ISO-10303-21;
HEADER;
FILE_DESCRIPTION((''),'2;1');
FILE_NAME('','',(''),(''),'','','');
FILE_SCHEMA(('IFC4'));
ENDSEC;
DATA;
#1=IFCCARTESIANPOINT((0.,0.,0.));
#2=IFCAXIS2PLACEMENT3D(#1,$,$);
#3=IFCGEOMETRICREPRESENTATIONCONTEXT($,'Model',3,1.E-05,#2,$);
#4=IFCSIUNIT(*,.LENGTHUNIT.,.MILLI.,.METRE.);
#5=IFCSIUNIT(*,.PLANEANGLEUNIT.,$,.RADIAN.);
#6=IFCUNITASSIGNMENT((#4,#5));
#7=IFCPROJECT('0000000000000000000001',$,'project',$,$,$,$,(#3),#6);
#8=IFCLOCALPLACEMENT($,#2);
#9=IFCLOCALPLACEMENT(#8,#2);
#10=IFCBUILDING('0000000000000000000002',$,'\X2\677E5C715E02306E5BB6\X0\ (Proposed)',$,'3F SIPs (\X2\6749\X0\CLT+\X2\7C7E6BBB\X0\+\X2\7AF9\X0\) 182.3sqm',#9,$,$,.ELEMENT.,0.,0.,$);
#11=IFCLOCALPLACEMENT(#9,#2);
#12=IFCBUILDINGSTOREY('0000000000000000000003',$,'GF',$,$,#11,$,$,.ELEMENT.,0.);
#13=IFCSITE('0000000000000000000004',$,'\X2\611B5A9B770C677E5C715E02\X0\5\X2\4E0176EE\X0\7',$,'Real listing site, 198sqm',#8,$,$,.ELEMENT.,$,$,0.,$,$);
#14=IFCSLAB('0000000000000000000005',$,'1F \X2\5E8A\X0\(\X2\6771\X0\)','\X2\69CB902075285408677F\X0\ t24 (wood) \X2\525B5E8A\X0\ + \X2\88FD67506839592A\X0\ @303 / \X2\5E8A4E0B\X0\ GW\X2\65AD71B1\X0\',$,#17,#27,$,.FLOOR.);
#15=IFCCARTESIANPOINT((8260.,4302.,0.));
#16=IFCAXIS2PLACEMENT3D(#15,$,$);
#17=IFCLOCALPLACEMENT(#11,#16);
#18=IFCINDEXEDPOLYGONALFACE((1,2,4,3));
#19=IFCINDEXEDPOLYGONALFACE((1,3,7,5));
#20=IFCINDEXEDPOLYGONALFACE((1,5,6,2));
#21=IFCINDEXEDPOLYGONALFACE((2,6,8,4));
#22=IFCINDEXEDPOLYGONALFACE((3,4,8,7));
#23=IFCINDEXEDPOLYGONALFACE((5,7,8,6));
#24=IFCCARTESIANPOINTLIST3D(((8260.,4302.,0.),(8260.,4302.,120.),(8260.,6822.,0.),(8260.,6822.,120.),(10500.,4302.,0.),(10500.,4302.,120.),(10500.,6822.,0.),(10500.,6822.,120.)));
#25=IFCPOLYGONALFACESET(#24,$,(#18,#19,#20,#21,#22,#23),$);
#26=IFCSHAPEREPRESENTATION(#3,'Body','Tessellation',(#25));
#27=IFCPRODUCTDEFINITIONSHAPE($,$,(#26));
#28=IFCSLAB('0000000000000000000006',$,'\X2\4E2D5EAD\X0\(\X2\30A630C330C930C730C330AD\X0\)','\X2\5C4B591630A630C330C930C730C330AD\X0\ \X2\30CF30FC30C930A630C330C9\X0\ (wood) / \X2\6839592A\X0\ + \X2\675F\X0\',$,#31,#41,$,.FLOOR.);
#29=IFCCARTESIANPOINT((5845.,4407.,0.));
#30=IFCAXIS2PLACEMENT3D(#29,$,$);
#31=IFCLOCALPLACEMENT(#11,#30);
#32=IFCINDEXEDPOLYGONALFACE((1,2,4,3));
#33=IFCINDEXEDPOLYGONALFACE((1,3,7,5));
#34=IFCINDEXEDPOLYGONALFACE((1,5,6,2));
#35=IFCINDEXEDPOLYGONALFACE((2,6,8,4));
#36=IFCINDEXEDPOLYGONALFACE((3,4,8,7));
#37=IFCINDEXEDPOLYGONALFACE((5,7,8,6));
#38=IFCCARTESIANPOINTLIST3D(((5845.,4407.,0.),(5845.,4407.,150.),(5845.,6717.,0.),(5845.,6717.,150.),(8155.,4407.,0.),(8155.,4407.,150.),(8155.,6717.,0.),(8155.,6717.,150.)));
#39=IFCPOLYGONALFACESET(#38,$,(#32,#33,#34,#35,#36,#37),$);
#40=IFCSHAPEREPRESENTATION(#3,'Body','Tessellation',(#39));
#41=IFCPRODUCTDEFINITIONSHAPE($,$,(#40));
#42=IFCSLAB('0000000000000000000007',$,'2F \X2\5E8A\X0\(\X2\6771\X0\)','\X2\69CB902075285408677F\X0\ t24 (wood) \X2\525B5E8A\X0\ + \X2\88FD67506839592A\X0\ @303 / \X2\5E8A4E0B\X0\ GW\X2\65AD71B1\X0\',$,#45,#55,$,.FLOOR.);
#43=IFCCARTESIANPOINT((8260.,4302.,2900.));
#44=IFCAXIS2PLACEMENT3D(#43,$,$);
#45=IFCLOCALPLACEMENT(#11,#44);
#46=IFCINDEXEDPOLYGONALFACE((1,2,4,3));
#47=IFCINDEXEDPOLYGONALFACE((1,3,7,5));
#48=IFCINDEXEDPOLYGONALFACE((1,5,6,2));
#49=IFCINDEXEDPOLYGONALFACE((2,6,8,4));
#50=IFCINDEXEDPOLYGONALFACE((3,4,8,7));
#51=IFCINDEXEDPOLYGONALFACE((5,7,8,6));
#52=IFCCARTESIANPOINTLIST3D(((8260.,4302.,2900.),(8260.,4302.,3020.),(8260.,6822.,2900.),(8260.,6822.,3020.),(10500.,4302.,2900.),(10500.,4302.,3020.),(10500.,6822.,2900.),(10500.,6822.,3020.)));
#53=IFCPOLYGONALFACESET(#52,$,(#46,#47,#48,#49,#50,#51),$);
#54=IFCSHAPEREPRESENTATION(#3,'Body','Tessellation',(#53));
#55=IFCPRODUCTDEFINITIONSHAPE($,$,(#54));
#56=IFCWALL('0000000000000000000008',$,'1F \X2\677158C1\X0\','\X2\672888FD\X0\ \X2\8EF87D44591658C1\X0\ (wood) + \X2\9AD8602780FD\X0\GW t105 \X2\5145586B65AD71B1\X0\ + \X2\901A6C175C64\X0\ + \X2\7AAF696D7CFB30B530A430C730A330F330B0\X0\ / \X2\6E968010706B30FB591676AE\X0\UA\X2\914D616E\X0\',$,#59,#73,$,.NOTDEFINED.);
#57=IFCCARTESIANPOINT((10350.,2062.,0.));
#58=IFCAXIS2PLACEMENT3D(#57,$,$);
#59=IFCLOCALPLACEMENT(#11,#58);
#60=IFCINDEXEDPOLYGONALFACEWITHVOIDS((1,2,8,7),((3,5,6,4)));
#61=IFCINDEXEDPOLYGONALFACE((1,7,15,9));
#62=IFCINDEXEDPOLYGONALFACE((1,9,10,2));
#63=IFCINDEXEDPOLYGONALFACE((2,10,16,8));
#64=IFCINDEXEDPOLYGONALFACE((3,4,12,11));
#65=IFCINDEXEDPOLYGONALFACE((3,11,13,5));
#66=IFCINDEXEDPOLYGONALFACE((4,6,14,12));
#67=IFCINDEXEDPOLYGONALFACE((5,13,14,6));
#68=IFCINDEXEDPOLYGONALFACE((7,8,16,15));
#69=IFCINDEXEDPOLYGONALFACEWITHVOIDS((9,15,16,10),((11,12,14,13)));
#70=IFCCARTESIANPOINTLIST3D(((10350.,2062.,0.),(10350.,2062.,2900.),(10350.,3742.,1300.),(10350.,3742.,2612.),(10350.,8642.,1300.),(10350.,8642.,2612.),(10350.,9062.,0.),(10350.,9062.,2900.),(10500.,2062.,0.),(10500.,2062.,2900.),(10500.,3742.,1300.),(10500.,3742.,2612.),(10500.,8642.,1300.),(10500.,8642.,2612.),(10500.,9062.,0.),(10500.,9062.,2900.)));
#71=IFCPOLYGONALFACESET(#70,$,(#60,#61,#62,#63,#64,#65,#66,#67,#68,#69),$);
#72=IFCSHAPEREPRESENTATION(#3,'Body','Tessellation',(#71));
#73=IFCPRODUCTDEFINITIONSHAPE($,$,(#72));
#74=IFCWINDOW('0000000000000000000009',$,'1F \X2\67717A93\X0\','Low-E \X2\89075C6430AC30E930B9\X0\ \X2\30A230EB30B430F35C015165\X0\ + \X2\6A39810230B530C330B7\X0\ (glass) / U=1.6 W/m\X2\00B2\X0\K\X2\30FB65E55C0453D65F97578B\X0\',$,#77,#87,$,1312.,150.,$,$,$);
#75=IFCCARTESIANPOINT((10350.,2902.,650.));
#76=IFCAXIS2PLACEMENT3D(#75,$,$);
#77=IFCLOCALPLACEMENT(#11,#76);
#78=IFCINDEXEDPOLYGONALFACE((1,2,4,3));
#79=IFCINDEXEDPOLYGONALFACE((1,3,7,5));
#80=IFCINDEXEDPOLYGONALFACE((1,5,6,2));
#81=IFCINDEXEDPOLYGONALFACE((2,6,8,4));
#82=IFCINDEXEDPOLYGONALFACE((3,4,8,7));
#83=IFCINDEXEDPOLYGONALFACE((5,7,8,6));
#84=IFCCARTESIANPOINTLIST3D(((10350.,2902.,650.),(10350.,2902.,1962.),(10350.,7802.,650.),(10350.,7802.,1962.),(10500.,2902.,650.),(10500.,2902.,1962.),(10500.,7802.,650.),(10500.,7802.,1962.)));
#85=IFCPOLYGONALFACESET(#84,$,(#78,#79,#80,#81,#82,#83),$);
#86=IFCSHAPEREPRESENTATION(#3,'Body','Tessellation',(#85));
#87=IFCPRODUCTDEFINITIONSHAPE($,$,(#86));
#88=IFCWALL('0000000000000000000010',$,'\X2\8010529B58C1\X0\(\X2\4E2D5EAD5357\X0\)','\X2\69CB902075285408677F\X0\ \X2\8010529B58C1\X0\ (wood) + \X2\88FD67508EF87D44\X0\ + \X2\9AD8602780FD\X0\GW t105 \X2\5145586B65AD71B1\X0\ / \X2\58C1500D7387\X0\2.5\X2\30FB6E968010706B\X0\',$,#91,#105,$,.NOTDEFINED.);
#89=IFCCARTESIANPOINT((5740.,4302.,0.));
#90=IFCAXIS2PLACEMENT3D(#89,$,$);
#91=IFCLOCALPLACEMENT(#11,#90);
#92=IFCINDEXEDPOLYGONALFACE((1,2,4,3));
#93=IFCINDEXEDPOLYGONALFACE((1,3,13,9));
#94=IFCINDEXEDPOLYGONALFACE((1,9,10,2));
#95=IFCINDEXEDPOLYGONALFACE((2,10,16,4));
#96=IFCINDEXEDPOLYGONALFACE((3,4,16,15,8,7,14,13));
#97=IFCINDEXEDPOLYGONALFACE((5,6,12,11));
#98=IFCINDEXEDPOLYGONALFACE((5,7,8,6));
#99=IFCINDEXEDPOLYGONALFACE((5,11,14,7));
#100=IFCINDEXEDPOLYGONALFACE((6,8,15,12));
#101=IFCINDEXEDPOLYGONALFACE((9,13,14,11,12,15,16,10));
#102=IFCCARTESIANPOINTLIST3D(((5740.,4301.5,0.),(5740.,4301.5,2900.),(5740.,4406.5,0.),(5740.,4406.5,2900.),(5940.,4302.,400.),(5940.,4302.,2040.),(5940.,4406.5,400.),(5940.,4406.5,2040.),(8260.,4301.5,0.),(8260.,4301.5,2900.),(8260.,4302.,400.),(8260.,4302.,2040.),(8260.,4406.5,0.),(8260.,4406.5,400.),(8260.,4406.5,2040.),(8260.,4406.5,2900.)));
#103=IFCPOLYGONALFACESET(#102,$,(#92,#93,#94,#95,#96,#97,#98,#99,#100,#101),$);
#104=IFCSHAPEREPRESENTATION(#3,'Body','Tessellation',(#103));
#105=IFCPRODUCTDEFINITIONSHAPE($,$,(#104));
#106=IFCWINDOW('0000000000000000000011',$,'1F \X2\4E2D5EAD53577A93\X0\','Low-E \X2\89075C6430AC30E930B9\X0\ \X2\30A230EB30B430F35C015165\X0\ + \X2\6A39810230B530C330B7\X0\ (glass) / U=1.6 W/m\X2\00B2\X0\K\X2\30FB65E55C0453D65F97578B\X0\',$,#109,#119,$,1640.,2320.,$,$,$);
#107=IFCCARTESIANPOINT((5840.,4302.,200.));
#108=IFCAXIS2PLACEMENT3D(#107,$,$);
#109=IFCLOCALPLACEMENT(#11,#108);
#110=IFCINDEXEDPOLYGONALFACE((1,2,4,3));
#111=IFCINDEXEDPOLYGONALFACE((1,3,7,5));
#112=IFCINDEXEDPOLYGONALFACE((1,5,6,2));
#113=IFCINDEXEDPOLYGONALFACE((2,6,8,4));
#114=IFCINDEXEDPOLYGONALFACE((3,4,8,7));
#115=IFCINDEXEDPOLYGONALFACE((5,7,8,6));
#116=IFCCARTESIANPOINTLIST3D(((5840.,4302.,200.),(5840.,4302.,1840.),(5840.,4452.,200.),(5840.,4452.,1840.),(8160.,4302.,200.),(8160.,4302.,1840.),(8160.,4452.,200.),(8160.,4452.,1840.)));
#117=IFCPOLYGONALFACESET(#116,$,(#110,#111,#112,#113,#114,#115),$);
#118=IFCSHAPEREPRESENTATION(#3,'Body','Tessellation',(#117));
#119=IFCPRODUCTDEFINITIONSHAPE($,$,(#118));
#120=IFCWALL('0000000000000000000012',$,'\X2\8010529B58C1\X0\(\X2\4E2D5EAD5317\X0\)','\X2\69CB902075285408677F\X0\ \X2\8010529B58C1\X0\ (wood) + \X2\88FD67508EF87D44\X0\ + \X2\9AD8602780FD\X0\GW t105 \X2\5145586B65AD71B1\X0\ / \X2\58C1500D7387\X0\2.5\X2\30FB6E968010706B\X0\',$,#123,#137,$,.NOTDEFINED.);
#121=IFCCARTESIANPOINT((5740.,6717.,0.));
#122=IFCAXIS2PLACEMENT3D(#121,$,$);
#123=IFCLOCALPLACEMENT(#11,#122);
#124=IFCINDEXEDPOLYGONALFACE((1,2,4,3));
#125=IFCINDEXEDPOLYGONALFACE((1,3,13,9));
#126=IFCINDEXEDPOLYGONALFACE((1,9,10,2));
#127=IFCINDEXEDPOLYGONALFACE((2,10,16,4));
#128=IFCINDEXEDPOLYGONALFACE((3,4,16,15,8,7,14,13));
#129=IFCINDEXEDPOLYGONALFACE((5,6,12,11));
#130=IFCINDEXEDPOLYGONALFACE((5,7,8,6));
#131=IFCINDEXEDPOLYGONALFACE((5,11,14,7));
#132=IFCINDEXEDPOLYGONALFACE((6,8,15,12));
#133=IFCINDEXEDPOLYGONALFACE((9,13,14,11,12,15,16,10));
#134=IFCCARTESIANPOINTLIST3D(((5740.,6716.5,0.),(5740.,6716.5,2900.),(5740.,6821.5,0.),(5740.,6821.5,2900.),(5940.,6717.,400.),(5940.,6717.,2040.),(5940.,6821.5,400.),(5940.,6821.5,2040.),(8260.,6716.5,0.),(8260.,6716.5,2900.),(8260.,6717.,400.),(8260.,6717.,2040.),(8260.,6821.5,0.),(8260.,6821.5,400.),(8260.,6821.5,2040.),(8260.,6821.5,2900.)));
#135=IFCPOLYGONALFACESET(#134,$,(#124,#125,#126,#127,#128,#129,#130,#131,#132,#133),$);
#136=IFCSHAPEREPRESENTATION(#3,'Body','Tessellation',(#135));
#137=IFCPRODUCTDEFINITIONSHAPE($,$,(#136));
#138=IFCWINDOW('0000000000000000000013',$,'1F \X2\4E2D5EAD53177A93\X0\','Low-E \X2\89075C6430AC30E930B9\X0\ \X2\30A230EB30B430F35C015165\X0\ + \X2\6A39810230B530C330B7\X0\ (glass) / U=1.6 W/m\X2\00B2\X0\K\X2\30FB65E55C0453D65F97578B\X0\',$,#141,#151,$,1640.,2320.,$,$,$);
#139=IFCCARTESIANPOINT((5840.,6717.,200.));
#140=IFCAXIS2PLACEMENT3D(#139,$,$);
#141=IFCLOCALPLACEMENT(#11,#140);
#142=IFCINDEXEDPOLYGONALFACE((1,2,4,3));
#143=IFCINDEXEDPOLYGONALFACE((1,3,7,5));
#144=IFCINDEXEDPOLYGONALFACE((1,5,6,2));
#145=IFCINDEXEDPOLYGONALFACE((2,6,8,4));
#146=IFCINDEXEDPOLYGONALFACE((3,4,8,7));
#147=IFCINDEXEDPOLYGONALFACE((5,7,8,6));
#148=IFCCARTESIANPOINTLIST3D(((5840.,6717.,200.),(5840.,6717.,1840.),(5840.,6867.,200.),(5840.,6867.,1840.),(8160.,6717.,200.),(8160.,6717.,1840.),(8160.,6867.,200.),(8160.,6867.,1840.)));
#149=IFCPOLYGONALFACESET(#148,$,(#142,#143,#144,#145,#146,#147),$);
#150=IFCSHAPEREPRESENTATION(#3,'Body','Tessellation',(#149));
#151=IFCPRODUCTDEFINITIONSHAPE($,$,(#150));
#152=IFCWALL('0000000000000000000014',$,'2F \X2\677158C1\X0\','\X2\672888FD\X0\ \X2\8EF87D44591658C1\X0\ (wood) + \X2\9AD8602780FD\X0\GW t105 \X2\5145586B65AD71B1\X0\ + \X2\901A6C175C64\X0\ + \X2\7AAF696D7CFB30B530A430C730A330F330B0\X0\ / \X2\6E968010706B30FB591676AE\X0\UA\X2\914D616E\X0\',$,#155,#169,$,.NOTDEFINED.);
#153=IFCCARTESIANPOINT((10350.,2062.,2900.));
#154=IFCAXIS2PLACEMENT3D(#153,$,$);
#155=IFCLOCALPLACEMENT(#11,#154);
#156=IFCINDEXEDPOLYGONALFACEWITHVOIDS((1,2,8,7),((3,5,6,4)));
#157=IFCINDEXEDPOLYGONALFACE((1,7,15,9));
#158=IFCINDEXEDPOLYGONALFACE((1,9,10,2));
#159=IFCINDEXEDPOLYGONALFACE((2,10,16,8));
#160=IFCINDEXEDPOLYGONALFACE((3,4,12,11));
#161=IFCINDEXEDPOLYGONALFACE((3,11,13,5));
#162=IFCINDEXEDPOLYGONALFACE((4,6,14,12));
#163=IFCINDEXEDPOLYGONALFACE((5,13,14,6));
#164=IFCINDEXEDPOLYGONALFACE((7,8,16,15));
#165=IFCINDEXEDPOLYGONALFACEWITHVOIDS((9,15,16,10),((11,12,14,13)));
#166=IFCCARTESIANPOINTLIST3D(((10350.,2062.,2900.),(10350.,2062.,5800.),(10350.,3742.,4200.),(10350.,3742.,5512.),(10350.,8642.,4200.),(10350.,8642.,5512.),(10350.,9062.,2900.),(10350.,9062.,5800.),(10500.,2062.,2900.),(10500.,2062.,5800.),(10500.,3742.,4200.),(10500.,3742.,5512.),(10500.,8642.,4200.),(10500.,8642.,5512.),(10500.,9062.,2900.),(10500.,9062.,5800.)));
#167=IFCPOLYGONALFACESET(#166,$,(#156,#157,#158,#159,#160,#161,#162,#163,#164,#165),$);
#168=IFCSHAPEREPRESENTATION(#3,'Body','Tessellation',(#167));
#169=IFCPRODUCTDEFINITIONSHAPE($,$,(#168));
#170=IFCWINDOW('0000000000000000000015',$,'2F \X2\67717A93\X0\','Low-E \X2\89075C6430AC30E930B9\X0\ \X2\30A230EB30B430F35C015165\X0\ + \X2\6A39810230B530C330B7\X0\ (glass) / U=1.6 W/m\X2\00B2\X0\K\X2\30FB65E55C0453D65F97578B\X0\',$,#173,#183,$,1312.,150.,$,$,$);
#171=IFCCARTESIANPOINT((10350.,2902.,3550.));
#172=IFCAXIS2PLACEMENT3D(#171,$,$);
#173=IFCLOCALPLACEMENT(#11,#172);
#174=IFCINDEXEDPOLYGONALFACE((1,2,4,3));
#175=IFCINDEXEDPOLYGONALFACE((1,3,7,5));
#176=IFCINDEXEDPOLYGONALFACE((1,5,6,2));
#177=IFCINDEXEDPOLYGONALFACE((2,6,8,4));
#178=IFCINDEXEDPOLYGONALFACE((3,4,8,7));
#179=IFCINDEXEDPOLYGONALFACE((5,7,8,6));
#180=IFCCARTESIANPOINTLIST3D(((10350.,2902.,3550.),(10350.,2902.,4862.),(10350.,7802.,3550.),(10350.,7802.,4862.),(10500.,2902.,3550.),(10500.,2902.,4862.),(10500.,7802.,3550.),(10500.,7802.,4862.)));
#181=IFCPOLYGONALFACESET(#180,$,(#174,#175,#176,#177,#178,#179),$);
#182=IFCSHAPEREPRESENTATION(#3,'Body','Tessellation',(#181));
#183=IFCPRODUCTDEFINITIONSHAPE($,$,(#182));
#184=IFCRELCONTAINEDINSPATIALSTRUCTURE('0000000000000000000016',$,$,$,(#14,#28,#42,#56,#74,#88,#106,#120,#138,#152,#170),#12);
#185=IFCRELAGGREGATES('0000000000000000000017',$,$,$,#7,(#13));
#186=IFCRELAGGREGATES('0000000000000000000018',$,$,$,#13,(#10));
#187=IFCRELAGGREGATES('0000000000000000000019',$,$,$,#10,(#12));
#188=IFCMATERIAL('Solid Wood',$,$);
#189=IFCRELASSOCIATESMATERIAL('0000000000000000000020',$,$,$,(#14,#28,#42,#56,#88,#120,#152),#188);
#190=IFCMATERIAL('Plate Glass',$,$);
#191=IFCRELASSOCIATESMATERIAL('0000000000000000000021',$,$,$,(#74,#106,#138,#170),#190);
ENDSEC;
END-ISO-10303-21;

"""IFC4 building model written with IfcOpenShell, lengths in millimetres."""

from ifc_helpers import new_model, si_unit, frame, frame_2d, origin, place, context, project, spatial, rectangle, extrude, material, element, fill, save


model = new_model("IFC4")

# Units and contexts
model_context = context("Model", 3, precision=1e-05, world=origin())
ifc_project = project(units=[si_unit("LENGTHUNIT", "METRE", prefix="MILLI"), si_unit("PLANEANGLEUNIT", "RADIAN")], contexts=[model_context])

# Site, building, storey
site_placement = place(None, origin())
site = spatial("IfcSite", under=ifc_project, at=site_placement, Name="愛媛県松山市5丁目7", ObjectType="Real listing site, 198sqm", CompositionType="ELEMENT", RefElevation=0.0)
building_placement = place(site_placement, origin())
building = spatial("IfcBuilding", under=site, at=building_placement, Name="松山市の家 (Proposed)", ObjectType="3F SIPs (杉CLT+籾殻+竹) 182.3sqm", CompositionType="ELEMENT", ElevationOfRefHeight=0.0, ElevationOfTerrain=0.0)
storey_placement = place(building_placement, origin())
storey = spatial("IfcBuildingStorey", under=building, at=storey_placement, Name="GF", CompositionType="ELEMENT", Elevation=0.0)

# Slabs
ifc_material_1 = material(Name="Solid Wood")
slab_1_placement = place(storey_placement, frame((8260.0, 4302.0, 0.0)))
element("IfcSlab", 1, at=slab_1_placement, inside=storey, material=ifc_material_1, Name="1F 床(東)", Description="構造用合板 t24 (wood) 剛床 + 製材根太 @303 / 床下 GW断熱", PredefinedType="FLOOR", context=model_context, shape_type="SweptSolid", body=[
    extrude(rectangle(XDim=2240.0, YDim=2520.0, at=frame_2d((1120.0, 1260.0))), frame((8260.0, 4302.0, 0.0)), (0.0, 0.0, 1.0), 120.0),
])
slab_2_placement = place(storey_placement, frame((5845.0, 4407.0, 0.0)))
element("IfcSlab", 2, at=slab_2_placement, inside=storey, material=ifc_material_1, Name="中庭(ウッドデッキ)", Description="屋外ウッドデッキ ハードウッド (wood) / 根太 + 束", PredefinedType="FLOOR", context=model_context, shape_type="SweptSolid", body=[
    extrude(rectangle(XDim=2310.0, YDim=2310.0, at=frame_2d((1155.0, 1155.0))), frame((5845.0, 4407.0, 0.0)), (0.0, 0.0, 1.0), 150.0),
])
slab_3_placement = place(storey_placement, frame((8260.0, 4302.0, 2900.0)))
element("IfcSlab", 3, at=slab_3_placement, inside=storey, material=ifc_material_1, Name="2F 床(東)", Description="構造用合板 t24 (wood) 剛床 + 製材根太 @303 / 床下 GW断熱", PredefinedType="FLOOR", context=model_context, shape_type="SweptSolid", body=[
    extrude(rectangle(XDim=2240.0, YDim=2520.0, at=frame_2d((1120.0, 1260.0))), frame((8260.0, 4302.0, 2900.0)), (0.0, 0.0, 1.0), 120.0),
])

# Walls, openings, windows
wall_1_placement = place(storey_placement, frame((10350.0, 2062.0, 0.0)))
wall_1 = element("IfcWall", 4, at=wall_1_placement, inside=storey, material=ifc_material_1, Name="1F 東壁", Description="木製 軸組外壁 (wood) + 高性能GW t105 充填断熱 + 通気層 + 窯業系サイディング / 準耐火・外皮UA配慮", PredefinedType="NOTDEFINED", context=model_context, shape_type="SweptSolid", body=[
    extrude(rectangle(XDim=150.0, YDim=7000.0, at=frame_2d((75.0, 3500.0))), frame((10350.0, 2062.0, 0.0)), (0.0, 0.0, 1.0), 2900.0),
])
opening_1_placement = place(storey_placement, frame((10350.0, 2902.0, 650.0)))
opening_1 = element("IfcOpeningElement", 5, at=opening_1_placement, cuts=wall_1, PredefinedType="NOTDEFINED", context=model_context, shape_type="SweptSolid", body=[
    extrude(rectangle(XDim=150.0, YDim=4900.0, at=frame_2d((75.0, 2450.0))), frame((10350.0, 2902.0, 650.0)), (0.0, 0.0, 1.0), 1312.0),
])
ifc_material_2 = material(Name="Plate Glass")
window_1_placement = place(storey_placement, frame((10350.0, 2902.0, 650.0)))
window_1 = element("IfcWindow", 6, at=window_1_placement, inside=storey, material=ifc_material_2, Name="1F 東窓", Description="Low-E 複層ガラス アルゴン封入 + 樹脂サッシ (glass) / U=1.6 W/m²K・日射取得型", OverallHeight=1312.0, OverallWidth=150.0, context=model_context, shape_type="SweptSolid", body=[
    extrude(rectangle(XDim=150.0, YDim=4900.0, at=frame_2d((75.0, 2450.0))), frame((10350.0, 2902.0, 650.0)), (0.0, 0.0, 1.0), 1312.0),
])
fill(opening_1, window_1)
wall_2_placement = place(storey_placement, frame((5740.0, 4302.0, 0.0)))
wall_2 = element("IfcWall", 7, at=wall_2_placement, inside=storey, material=ifc_material_1, Name="耐力壁(中庭南)", Description="構造用合板 耐力壁 (wood) + 製材軸組 + 高性能GW t105 充填断熱 / 壁倍率2.5・準耐火", PredefinedType="NOTDEFINED", context=model_context, shape_type="SweptSolid", body=[
    extrude(rectangle(XDim=2520.0, YDim=105.0, at=frame_2d((1260.0, 52.0))), frame((5740.0, 4302.0, 0.0)), (0.0, 0.0, 1.0), 2900.0),
])
opening_2_placement = place(storey_placement, frame((5840.0, 4302.0, 200.0)))
opening_2 = element("IfcOpeningElement", 8, at=opening_2_placement, cuts=wall_2, PredefinedType="NOTDEFINED", context=model_context, shape_type="SweptSolid", body=[
    extrude(rectangle(XDim=2320.0, YDim=150.0, at=frame_2d((1160.0, 75.0))), frame((5840.0, 4302.0, 200.0)), (0.0, 0.0, 1.0), 1640.0),
])
window_2_placement = place(storey_placement, frame((5840.0, 4302.0, 200.0)))
window_2 = element("IfcWindow", 9, at=window_2_placement, inside=storey, material=ifc_material_2, Name="1F 中庭南窓", Description="Low-E 複層ガラス アルゴン封入 + 樹脂サッシ (glass) / U=1.6 W/m²K・日射取得型", OverallHeight=1640.0, OverallWidth=2320.0, context=model_context, shape_type="SweptSolid", body=[
    extrude(rectangle(XDim=2320.0, YDim=150.0, at=frame_2d((1160.0, 75.0))), frame((5840.0, 4302.0, 200.0)), (0.0, 0.0, 1.0), 1640.0),
])
fill(opening_2, window_2)
wall_3_placement = place(storey_placement, frame((5740.0, 6717.0, 0.0)))
wall_3 = element("IfcWall", 10, at=wall_3_placement, inside=storey, material=ifc_material_1, Name="耐力壁(中庭北)", Description="構造用合板 耐力壁 (wood) + 製材軸組 + 高性能GW t105 充填断熱 / 壁倍率2.5・準耐火", PredefinedType="NOTDEFINED", context=model_context, shape_type="SweptSolid", body=[
    extrude(rectangle(XDim=2520.0, YDim=105.0, at=frame_2d((1260.0, 52.0))), frame((5740.0, 6717.0, 0.0)), (0.0, 0.0, 1.0), 2900.0),
])
opening_3_placement = place(storey_placement, frame((5840.0, 6717.0, 200.0)))
opening_3 = element("IfcOpeningElement", 11, at=opening_3_placement, cuts=wall_3, PredefinedType="NOTDEFINED", context=model_context, shape_type="SweptSolid", body=[
    extrude(rectangle(XDim=2320.0, YDim=150.0, at=frame_2d((1160.0, 75.0))), frame((5840.0, 6717.0, 200.0)), (0.0, 0.0, 1.0), 1640.0),
])
window_3_placement = place(storey_placement, frame((5840.0, 6717.0, 200.0)))
window_3 = element("IfcWindow", 12, at=window_3_placement, inside=storey, material=ifc_material_2, Name="1F 中庭北窓", Description="Low-E 複層ガラス アルゴン封入 + 樹脂サッシ (glass) / U=1.6 W/m²K・日射取得型", OverallHeight=1640.0, OverallWidth=2320.0, context=model_context, shape_type="SweptSolid", body=[
    extrude(rectangle(XDim=2320.0, YDim=150.0, at=frame_2d((1160.0, 75.0))), frame((5840.0, 6717.0, 200.0)), (0.0, 0.0, 1.0), 1640.0),
])
fill(opening_3, window_3)

# Wall, opening, window
wall_4_placement = place(storey_placement, frame((10350.0, 2062.0, 2900.0)))
wall_4 = element("IfcWall", 13, at=wall_4_placement, inside=storey, material=ifc_material_1, Name="2F 東壁", Description="木製 軸組外壁 (wood) + 高性能GW t105 充填断熱 + 通気層 + 窯業系サイディング / 準耐火・外皮UA配慮", PredefinedType="NOTDEFINED", context=model_context, shape_type="SweptSolid", body=[
    extrude(rectangle(XDim=150.0, YDim=7000.0, at=frame_2d((75.0, 3500.0))), frame((10350.0, 2062.0, 2900.0)), (0.0, 0.0, 1.0), 2900.0),
])
opening_4_placement = place(storey_placement, frame((10350.0, 2902.0, 3550.0)))
opening_4 = element("IfcOpeningElement", 14, at=opening_4_placement, cuts=wall_4, PredefinedType="NOTDEFINED", context=model_context, shape_type="SweptSolid", body=[
    extrude(rectangle(XDim=150.0, YDim=4900.0, at=frame_2d((75.0, 2450.0))), frame((10350.0, 2902.0, 3550.0)), (0.0, 0.0, 1.0), 1312.0),
])
window_4_placement = place(storey_placement, frame((10350.0, 2902.0, 3550.0)))
window_4 = element("IfcWindow", 15, at=window_4_placement, inside=storey, material=ifc_material_2, Name="2F 東窓", Description="Low-E 複層ガラス アルゴン封入 + 樹脂サッシ (glass) / U=1.6 W/m²K・日射取得型", OverallHeight=1312.0, OverallWidth=150.0, context=model_context, shape_type="SweptSolid", body=[
    extrude(rectangle(XDim=150.0, YDim=4900.0, at=frame_2d((75.0, 2450.0))), frame((10350.0, 2902.0, 3550.0)), (0.0, 0.0, 1.0), 1312.0),
])
fill(opening_4, window_4)

save(model, "model.ifc")
